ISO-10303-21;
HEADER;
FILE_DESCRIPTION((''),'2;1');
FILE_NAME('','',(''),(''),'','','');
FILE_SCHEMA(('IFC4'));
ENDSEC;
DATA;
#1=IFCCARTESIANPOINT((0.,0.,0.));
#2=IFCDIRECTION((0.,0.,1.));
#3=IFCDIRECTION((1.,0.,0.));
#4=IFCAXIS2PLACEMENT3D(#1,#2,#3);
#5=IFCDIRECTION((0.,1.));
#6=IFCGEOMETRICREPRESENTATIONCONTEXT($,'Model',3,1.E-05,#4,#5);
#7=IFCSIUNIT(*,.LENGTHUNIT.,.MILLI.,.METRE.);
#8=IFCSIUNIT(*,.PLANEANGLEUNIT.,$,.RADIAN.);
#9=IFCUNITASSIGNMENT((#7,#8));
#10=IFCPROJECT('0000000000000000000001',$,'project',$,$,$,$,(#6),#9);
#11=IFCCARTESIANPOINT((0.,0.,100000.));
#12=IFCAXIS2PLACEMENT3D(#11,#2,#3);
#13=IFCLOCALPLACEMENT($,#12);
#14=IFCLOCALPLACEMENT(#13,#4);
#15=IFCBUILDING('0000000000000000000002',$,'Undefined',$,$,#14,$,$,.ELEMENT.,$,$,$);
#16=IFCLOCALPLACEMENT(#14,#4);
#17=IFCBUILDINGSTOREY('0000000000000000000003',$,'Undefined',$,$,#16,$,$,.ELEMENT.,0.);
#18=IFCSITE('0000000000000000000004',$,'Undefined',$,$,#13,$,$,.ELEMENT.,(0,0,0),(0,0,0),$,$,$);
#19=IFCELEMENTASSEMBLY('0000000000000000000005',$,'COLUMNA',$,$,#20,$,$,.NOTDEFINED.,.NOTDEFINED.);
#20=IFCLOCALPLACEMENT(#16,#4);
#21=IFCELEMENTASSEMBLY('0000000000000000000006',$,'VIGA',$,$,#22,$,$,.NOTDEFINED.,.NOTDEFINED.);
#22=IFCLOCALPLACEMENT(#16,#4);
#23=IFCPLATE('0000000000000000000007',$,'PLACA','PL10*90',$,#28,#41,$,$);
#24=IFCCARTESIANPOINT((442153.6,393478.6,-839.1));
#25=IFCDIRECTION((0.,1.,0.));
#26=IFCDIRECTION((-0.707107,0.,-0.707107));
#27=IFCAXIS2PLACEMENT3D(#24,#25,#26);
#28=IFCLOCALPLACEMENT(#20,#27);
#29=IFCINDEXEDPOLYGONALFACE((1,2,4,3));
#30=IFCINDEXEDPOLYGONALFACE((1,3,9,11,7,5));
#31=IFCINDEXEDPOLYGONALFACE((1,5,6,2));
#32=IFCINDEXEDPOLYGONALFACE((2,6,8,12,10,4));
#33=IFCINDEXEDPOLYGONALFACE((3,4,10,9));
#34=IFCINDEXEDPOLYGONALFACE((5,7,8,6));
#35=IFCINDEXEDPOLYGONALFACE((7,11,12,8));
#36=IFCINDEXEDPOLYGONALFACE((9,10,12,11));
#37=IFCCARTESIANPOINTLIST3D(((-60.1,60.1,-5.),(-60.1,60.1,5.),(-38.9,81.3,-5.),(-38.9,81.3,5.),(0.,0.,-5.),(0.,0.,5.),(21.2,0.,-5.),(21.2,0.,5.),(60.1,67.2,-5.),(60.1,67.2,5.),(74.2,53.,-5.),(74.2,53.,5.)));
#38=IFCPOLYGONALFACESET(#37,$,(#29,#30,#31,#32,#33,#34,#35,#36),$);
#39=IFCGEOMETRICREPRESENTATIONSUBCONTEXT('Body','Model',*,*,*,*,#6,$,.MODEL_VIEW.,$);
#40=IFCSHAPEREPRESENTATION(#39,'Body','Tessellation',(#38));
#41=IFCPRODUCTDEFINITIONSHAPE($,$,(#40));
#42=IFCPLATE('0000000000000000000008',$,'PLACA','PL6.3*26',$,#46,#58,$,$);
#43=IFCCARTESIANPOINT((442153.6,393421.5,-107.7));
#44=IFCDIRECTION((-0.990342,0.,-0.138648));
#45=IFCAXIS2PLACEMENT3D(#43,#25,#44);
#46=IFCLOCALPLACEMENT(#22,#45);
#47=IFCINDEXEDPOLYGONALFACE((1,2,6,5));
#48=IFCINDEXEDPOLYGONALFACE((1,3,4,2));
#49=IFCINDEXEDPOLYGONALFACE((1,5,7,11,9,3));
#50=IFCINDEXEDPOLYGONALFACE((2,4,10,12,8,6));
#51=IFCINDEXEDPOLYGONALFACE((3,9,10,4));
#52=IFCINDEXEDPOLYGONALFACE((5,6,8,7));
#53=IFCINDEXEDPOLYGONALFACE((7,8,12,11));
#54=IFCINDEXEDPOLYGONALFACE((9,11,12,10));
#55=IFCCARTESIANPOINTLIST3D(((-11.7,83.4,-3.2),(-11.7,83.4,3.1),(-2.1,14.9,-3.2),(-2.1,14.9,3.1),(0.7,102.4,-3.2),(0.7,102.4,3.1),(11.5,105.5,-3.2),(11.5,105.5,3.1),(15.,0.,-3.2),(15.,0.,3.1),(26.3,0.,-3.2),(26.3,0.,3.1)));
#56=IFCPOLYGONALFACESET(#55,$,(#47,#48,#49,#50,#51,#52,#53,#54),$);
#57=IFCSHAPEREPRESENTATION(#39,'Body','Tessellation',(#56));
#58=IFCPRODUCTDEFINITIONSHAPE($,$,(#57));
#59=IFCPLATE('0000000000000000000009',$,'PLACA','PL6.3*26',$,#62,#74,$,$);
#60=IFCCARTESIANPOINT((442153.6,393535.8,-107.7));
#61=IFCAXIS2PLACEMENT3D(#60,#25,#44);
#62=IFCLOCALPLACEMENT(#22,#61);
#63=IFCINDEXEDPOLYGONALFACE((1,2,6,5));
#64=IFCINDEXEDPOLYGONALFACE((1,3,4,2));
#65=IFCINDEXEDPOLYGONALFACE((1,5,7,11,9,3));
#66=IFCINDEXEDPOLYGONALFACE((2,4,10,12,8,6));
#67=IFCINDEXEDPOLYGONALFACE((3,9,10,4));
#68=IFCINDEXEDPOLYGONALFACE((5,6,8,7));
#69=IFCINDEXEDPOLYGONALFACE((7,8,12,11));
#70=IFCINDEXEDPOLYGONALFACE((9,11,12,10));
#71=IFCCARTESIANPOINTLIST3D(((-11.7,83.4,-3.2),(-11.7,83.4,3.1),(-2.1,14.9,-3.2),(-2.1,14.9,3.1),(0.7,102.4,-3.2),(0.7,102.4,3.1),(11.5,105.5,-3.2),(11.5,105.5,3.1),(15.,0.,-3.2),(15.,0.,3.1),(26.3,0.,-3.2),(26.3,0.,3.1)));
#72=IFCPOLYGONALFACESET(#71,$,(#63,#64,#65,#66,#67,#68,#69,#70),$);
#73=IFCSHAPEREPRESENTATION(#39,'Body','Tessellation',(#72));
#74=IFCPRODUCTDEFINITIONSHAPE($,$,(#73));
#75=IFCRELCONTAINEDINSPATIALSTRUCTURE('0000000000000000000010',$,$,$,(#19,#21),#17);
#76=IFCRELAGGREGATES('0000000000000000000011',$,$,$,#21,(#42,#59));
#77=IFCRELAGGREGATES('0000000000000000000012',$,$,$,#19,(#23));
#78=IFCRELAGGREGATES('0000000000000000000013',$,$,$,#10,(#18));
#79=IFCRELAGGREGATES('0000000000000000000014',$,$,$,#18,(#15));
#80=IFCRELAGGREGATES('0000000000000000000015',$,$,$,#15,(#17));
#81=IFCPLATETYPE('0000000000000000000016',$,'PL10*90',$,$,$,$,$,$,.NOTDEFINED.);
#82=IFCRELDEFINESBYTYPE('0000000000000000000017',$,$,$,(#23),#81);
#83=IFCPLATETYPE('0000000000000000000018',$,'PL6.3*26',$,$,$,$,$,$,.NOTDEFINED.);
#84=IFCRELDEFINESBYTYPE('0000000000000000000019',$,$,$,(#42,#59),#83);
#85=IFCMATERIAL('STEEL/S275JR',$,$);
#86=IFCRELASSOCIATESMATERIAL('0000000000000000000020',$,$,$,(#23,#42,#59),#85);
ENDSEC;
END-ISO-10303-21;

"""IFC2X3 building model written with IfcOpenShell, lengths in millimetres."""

from ifc_helpers import new_model, si_unit, direction, frame, origin_with_axes, place, context, subcontext, project, spatial, polyline, outline, extrude, material, type_object, element, aggregate, save


model = new_model("IFC2X3")

# Units and contexts
model_context = context("Model", 3, precision=1e-05, world=origin_with_axes(), true_north=direction((0.0, 1.0)))
body_context = subcontext(model_context, "Body", "Model", "MODEL_VIEW")
ifc_project = project(units=[si_unit("LENGTHUNIT", "METRE", prefix="MILLI"), si_unit("PLANEANGLEUNIT", "RADIAN")], contexts=[model_context])

# Site, building, storey
site_placement = place(None, frame((0.0, 0.0, 100000.0), z_axis=(0.0, 0.0, 1.0), x_axis=(1.0, 0.0, 0.0)))
site = spatial("IfcSite", under=ifc_project, at=site_placement, Name="Undefined", CompositionType="ELEMENT", RefLatitude=(0, 0, 0), RefLongitude=(0, 0, 0))
building_placement = place(site_placement, origin_with_axes())
building = spatial("IfcBuilding", under=site, at=building_placement, Name="Undefined", CompositionType="ELEMENT")
storey_placement = place(building_placement, origin_with_axes())
storey = spatial("IfcBuildingStorey", under=building, at=storey_placement, Name="Undefined", CompositionType="ELEMENT", Elevation=0.0)

# Shared definitions
ifc_material_1 = material(Name="STEEL/S275JR")

# Element assembly
assembly_1_placement = place(storey_placement, origin_with_axes())
assembly_1 = element("IfcElementAssembly", 1, at=assembly_1_placement, inside=storey, Name="COLUMNA", AssemblyPlace="NOTDEFINED", PredefinedType="NOTDEFINED")

# Element assembly
assembly_2_placement = place(storey_placement, origin_with_axes())
assembly_2 = element("IfcElementAssembly", 2, at=assembly_2_placement, inside=storey, Name="VIGA", AssemblyPlace="NOTDEFINED", PredefinedType="NOTDEFINED")

# Plates
plate_type_1 = type_object("IfcPlateType", Name="PL10*90", PredefinedType="NOTDEFINED")
plate_1_placement = place(assembly_1_placement, frame((442153.6, 393478.6, -839.1), z_axis=(0.0, 1.0, 0.0), x_axis=(-0.707107, 0.0, -0.707107)))
plate_1 = element("IfcPlate", 3, at=plate_1_placement, type_object=plate_type_1, material=ifc_material_1, Name="PLACA", Description="PL10*90", context=body_context, shape_type="SweptSolid", body=[
    extrude(outline(polyline([(0.0, 0.0), (21.2, 0.0), (74.2, 53.0), (60.1, 67.2), (-38.9, 81.3), (-60.1, 60.1), (0.0, 0.0)])), frame((0.0, 0.0, -5.0), z_axis=(0.0, 0.0, 1.0), x_axis=(1.0, 0.0, 0.0)), (0.0, 0.0, 1.0), 10.0),
])
plate_type_2 = type_object("IfcPlateType", Name="PL6.3*26", PredefinedType="NOTDEFINED")
plate_2_placement = place(assembly_2_placement, frame((442153.6, 393421.5, -107.7), z_axis=(0.0, 1.0, 0.0), x_axis=(-0.990342, 0.0, -0.138648)))
plate_2 = element("IfcPlate", 4, at=plate_2_placement, type_object=plate_type_2, material=ifc_material_1, Name="PLACA", Description="PL6.3*26", context=body_context, shape_type="SweptSolid", body=[
    extrude(outline(polyline([(-2.1, 14.9), (15.0, 0.0), (26.3, 0.0), (11.5, 105.5), (0.7, 102.4), (-11.7, 83.4), (-2.1, 14.9)])), frame((0.0, 0.0, -3.1), z_axis=(0.0, 0.0, 1.0), x_axis=(1.0, 0.0, 0.0)), (0.0, 0.0, 1.0), 6.3),
])
plate_3_placement = place(assembly_2_placement, frame((442153.6, 393535.8, -107.7), z_axis=(0.0, 1.0, 0.0), x_axis=(-0.990342, 0.0, -0.138648)))
plate_3 = element("IfcPlate", 5, at=plate_3_placement, type_object=plate_type_2, material=ifc_material_1, Name="PLACA", Description="PL6.3*26", context=body_context, shape_type="SweptSolid", body=[
    extrude(outline(polyline([(-2.1, 14.9), (15.0, 0.0), (26.3, 0.0), (11.5, 105.5), (0.7, 102.4), (-11.7, 83.4), (-2.1, 14.9)])), frame((0.0, 0.0, -3.1), z_axis=(0.0, 0.0, 1.0), x_axis=(1.0, 0.0, 0.0)), (0.0, 0.0, 1.0), 6.3),
])
aggregate(assembly_2, [plate_2, plate_3])

aggregate(assembly_1, [plate_1])

save(model, "model.ifc")
